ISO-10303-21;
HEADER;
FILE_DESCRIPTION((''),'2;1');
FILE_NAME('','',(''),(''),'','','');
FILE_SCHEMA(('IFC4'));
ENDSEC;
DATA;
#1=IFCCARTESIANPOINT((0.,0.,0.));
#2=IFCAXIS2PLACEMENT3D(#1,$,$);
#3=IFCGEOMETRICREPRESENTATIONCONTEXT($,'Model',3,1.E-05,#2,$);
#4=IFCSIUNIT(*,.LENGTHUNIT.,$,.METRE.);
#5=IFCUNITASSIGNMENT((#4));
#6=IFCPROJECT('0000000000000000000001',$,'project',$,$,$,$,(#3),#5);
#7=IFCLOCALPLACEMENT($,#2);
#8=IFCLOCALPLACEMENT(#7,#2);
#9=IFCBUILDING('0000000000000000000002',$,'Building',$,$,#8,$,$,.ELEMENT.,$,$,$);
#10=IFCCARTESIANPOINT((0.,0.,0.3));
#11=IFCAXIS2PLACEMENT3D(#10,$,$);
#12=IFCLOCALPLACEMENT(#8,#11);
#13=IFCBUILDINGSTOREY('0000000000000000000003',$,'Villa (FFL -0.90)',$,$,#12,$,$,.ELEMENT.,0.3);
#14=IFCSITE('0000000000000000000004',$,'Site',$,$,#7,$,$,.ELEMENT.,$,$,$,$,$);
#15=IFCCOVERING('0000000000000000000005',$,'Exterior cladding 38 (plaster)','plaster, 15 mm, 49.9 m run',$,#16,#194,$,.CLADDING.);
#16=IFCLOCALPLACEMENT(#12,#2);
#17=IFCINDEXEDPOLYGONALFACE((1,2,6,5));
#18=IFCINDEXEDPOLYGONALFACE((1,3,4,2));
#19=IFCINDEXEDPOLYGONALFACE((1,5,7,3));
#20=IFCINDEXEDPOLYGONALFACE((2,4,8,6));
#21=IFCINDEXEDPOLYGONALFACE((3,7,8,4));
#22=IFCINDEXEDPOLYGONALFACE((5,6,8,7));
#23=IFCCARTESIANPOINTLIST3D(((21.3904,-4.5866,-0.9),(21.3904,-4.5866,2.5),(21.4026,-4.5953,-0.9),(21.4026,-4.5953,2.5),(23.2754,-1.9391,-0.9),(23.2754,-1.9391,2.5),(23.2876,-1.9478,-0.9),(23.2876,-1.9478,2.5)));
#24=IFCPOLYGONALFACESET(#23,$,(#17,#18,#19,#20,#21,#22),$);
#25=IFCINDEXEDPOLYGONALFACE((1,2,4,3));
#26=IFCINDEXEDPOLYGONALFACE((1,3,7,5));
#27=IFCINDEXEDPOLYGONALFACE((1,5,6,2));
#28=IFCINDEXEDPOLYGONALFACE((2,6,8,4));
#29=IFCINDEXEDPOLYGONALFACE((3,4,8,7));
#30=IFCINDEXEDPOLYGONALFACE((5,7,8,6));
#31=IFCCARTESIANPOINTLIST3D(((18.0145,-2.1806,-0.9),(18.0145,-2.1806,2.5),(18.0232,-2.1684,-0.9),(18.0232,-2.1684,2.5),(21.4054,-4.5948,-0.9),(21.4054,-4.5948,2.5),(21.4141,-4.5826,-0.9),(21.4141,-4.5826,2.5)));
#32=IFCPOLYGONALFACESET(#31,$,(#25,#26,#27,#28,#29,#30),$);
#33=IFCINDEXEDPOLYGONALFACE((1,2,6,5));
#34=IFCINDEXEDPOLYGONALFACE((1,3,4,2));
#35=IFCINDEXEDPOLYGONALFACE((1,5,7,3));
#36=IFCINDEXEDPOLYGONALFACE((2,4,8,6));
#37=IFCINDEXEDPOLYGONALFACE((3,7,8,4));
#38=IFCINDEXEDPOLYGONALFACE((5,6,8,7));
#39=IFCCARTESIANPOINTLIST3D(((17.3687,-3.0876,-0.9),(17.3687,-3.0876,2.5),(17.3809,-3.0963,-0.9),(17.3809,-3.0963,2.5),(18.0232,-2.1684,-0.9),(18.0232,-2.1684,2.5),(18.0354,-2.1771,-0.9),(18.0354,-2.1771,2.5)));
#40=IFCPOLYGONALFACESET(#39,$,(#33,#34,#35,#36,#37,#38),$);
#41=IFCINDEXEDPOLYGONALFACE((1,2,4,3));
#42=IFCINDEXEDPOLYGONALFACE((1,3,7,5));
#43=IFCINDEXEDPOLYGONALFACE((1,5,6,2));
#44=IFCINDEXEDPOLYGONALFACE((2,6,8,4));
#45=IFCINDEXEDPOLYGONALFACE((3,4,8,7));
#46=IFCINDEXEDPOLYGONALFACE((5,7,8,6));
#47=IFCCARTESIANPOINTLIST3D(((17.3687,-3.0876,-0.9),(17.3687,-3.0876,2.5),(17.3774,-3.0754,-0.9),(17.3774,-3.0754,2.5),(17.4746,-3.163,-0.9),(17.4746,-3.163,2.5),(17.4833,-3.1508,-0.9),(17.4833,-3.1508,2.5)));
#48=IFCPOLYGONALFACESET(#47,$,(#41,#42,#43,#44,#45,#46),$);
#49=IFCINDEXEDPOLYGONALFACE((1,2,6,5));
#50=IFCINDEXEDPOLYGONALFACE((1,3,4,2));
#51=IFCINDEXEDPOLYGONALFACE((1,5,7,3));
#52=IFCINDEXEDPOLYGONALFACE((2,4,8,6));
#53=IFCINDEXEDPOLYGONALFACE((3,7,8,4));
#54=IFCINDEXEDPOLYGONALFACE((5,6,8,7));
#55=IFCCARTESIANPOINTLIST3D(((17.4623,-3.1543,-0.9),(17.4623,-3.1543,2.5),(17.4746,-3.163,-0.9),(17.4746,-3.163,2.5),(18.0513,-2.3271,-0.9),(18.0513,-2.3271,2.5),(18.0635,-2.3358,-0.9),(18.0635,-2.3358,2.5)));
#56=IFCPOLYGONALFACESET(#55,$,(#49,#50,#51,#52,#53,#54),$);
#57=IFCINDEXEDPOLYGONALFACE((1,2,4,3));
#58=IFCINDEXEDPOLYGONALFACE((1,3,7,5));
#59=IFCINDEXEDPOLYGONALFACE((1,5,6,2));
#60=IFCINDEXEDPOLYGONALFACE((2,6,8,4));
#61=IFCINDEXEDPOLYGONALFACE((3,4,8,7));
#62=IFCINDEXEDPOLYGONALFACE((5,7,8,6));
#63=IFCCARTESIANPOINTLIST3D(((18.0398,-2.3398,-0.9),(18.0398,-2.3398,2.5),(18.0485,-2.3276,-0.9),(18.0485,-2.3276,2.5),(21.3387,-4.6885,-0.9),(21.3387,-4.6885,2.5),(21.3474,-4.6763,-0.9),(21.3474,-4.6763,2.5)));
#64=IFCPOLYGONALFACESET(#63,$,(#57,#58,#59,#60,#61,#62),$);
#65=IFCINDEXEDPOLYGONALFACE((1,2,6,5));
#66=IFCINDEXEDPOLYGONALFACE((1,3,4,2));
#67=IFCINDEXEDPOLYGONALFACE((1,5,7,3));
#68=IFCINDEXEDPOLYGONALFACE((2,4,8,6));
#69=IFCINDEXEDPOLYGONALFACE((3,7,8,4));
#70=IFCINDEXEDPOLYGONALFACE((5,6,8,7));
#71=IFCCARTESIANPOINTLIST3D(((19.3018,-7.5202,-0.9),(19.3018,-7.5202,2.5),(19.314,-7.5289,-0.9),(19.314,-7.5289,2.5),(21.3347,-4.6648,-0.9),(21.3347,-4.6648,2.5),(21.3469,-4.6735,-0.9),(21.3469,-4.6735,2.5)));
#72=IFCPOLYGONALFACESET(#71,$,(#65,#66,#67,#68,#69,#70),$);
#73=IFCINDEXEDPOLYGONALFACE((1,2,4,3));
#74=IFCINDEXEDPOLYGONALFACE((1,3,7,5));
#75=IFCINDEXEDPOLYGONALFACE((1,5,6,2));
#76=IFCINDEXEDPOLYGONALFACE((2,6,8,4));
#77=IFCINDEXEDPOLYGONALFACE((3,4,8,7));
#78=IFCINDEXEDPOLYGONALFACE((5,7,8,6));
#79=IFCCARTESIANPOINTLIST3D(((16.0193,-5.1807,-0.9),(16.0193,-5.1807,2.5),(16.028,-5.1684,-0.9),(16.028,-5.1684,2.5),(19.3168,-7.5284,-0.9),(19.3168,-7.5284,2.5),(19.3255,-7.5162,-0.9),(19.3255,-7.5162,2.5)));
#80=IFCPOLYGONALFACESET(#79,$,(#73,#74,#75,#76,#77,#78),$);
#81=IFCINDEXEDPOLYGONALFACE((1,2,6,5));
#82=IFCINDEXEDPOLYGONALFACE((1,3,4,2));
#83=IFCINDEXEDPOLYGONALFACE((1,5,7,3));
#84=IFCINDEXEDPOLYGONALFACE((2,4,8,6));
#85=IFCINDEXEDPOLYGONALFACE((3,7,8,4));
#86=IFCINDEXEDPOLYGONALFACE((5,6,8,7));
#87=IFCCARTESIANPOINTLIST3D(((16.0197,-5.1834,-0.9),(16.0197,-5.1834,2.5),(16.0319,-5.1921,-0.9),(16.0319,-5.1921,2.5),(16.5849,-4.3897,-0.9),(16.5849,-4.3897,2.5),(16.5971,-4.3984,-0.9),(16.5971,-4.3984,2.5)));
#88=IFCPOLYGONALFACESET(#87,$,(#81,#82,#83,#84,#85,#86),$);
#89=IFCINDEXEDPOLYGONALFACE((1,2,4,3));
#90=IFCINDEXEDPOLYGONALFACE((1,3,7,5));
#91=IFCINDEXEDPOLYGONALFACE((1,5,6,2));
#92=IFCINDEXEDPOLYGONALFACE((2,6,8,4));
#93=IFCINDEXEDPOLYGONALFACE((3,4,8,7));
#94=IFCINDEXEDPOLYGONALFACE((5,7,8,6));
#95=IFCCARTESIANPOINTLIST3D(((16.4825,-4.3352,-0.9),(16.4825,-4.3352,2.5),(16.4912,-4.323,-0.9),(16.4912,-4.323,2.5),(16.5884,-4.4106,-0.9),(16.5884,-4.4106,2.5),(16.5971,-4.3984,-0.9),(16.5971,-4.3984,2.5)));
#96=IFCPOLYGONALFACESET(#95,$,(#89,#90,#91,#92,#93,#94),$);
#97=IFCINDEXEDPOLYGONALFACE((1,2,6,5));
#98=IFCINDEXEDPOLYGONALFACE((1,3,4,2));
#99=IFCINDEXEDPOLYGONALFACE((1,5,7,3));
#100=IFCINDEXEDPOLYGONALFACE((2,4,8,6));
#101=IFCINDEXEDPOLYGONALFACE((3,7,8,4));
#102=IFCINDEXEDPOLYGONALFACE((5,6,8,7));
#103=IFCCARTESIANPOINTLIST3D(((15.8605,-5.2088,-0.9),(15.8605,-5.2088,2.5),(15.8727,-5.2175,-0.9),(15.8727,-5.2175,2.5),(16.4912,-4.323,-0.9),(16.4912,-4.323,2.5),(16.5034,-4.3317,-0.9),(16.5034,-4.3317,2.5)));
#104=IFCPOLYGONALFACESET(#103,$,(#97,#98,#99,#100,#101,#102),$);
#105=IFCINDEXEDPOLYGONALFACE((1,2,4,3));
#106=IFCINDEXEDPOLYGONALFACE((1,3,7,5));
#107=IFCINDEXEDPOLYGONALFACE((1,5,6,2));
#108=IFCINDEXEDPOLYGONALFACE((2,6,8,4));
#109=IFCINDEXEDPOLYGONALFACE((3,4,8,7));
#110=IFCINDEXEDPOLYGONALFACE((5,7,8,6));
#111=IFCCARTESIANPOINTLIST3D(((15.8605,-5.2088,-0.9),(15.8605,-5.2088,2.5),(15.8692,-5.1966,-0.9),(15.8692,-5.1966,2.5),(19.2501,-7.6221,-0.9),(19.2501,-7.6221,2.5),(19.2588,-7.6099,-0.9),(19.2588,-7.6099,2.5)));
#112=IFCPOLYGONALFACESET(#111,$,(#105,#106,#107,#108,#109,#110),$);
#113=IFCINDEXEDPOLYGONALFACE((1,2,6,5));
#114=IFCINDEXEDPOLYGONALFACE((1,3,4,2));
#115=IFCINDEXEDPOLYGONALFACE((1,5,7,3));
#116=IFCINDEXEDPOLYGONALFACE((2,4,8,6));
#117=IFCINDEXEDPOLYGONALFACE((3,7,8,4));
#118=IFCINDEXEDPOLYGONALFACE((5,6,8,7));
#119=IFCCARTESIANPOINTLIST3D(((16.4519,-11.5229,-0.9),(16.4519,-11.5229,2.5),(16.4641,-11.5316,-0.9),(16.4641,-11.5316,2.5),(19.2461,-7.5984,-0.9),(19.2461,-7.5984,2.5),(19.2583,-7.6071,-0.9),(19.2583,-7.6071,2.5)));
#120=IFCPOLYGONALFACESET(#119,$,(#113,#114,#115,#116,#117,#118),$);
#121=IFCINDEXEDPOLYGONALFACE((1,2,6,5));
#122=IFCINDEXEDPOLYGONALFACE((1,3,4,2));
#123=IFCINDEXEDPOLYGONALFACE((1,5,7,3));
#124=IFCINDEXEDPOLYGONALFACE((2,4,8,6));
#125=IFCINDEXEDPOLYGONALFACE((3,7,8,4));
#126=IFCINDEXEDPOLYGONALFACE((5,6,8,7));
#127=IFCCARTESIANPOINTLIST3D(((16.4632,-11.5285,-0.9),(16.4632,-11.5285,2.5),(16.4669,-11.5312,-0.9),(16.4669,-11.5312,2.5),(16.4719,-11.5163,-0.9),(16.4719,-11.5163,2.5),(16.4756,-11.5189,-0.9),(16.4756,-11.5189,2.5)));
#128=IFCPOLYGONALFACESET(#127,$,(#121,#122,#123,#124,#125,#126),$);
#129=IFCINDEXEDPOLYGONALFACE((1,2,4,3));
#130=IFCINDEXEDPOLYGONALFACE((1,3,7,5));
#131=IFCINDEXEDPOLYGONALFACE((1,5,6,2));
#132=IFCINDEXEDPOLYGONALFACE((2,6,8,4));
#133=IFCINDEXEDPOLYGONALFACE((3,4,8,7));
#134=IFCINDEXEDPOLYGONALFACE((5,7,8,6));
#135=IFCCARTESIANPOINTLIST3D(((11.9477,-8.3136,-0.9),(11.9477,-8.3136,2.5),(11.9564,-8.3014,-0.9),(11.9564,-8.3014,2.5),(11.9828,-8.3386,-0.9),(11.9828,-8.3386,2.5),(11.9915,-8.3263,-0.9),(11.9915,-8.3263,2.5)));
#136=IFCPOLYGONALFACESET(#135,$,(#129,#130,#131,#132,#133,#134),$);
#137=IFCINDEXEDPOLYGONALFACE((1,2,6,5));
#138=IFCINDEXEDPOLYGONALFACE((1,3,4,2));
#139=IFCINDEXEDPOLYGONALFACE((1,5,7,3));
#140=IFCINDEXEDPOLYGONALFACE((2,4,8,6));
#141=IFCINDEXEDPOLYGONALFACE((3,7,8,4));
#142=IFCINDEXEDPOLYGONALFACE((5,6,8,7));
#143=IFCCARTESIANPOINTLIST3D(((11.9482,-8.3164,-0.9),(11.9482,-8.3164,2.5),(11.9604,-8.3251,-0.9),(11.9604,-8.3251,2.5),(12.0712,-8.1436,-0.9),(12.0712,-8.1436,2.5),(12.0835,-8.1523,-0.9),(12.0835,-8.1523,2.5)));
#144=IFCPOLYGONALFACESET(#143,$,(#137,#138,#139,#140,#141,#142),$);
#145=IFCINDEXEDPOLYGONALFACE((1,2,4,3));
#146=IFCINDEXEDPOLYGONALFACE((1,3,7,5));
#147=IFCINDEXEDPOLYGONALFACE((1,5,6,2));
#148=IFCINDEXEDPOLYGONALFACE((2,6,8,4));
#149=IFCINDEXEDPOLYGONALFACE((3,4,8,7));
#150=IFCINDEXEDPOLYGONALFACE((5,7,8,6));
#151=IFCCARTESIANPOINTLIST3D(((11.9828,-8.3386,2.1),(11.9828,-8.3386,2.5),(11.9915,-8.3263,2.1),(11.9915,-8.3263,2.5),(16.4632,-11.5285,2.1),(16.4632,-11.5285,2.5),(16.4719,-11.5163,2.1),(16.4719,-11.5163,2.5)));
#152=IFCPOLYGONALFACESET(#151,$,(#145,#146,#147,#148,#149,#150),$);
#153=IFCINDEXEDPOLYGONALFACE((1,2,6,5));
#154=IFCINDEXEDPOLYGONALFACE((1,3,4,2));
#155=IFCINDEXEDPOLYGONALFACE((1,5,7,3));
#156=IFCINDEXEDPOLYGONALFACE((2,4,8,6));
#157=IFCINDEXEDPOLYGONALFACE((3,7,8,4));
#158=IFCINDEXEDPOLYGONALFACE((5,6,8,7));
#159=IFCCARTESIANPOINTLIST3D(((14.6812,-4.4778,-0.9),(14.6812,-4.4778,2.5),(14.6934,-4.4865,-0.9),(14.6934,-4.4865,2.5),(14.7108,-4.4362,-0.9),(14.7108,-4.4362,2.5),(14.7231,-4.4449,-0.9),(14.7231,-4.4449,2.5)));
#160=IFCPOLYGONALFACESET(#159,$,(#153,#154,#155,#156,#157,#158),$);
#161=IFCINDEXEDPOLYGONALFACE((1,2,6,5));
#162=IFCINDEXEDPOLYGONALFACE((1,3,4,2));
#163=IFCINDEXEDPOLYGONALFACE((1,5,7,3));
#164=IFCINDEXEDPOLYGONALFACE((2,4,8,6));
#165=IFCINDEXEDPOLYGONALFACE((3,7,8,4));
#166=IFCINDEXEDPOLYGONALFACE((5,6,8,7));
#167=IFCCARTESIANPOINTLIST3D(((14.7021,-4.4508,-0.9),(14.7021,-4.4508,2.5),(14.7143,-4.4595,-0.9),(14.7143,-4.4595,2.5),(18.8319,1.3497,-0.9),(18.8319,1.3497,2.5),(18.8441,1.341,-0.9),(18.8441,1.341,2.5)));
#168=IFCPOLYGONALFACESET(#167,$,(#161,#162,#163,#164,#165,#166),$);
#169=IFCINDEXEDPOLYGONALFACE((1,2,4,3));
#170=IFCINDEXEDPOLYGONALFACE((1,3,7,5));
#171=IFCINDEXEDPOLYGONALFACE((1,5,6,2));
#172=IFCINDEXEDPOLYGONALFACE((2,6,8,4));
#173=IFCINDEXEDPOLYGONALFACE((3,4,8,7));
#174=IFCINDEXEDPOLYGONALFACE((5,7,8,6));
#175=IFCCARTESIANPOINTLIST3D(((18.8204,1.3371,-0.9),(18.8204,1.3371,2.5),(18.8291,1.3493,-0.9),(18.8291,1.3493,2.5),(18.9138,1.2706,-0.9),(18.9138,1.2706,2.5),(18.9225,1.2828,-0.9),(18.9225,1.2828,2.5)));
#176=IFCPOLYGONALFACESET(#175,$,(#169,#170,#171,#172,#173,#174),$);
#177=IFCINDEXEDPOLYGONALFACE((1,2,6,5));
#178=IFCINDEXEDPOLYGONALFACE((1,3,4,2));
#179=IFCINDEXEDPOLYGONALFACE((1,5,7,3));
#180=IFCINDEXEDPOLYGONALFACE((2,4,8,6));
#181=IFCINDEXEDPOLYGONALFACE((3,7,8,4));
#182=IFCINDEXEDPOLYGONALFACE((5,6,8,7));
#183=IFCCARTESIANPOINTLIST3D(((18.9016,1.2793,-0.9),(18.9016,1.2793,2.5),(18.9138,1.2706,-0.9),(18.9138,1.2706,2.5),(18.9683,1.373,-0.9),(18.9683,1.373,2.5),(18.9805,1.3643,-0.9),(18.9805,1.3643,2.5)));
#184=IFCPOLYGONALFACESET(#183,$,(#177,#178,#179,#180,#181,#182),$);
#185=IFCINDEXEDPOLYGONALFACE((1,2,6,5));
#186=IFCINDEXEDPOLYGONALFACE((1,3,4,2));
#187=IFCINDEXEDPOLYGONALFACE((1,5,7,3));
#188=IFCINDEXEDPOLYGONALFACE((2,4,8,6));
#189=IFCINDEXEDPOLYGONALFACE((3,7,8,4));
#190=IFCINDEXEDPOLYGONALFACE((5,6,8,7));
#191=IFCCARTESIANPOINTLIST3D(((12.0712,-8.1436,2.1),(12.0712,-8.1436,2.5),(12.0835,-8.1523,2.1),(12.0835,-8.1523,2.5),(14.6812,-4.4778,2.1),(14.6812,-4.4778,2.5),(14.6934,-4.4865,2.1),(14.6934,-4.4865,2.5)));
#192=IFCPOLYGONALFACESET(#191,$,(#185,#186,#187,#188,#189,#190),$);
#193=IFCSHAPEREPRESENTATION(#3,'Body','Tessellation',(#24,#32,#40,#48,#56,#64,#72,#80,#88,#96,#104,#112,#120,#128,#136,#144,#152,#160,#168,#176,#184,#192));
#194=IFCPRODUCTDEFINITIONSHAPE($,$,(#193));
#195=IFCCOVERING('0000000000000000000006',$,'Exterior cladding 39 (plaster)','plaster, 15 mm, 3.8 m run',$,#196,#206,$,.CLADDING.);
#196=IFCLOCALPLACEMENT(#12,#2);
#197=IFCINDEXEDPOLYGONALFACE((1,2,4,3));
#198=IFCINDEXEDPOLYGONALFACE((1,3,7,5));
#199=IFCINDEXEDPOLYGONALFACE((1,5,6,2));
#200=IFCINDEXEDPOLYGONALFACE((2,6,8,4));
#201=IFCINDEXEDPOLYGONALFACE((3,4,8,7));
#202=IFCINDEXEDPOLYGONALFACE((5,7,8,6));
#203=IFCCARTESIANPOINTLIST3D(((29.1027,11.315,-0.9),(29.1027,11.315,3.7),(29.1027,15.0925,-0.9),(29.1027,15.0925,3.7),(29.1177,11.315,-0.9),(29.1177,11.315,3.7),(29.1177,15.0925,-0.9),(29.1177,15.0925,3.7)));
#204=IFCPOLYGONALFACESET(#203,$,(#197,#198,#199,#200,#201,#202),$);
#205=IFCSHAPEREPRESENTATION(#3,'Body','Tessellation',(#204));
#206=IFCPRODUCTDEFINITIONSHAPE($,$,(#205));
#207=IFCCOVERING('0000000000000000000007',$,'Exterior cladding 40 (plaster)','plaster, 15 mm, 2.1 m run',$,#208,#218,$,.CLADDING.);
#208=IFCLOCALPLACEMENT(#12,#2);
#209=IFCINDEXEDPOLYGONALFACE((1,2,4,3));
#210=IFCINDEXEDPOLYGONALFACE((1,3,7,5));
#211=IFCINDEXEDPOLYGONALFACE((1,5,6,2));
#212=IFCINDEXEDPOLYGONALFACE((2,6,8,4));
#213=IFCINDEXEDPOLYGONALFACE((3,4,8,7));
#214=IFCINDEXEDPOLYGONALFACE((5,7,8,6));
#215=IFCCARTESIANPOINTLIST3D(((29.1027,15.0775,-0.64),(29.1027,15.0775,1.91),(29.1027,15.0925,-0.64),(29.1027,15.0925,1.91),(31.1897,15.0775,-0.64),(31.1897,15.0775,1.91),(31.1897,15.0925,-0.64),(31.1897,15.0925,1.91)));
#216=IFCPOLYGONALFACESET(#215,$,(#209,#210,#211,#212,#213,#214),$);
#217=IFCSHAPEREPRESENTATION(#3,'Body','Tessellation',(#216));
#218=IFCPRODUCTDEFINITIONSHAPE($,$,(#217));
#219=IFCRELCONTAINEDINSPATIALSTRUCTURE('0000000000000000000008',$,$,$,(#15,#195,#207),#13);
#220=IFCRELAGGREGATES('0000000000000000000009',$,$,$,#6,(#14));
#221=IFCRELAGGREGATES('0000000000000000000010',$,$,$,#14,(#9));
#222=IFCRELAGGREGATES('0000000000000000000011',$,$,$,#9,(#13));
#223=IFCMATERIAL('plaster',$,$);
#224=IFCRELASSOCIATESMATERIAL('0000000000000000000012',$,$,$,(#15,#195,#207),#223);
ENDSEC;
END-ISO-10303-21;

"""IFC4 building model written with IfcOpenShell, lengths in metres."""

from ifc_helpers import new_model, si_unit, frame, origin, origin_with_axes, place, context, project, spatial, polyline, outline, extrude, material, element, save


model = new_model("IFC4")

# Units and contexts
model_context = context("Model", 3, precision=1e-05, world=origin())
ifc_project = project(units=[si_unit("LENGTHUNIT", "METRE")], contexts=[model_context])

# Site, building, storey
site_placement = place(None, origin())
site = spatial("IfcSite", under=ifc_project, at=site_placement, Name="Site", CompositionType="ELEMENT")
building_placement = place(site_placement, origin())
building = spatial("IfcBuilding", under=site, at=building_placement, Name="Building", CompositionType="ELEMENT")
storey_placement = place(building_placement, frame((0.0, 0.0, 0.3)))
storey = spatial("IfcBuildingStorey", under=building, at=storey_placement, Name="Villa (FFL -0.90)", CompositionType="ELEMENT", Elevation=0.3)

# Coverings
ifc_material = material(Name="plaster")
covering_1_placement = place(storey_placement, origin_with_axes())
element("IfcCovering", 1, at=covering_1_placement, inside=storey, material=ifc_material, Name="Exterior cladding 38 (plaster)", Description="plaster, 15 mm, 49.9 m run", PredefinedType="CLADDING", context=model_context, shape_type="SweptSolid", body=[
    extrude(outline(polyline([(23.2754, -1.9391), (21.3904, -4.5866), (21.4026, -4.5953), (23.2876, -1.9478), (23.2754, -1.9391)])), frame((0.0, 0.0, -0.9)), (0.0, 0.0, 1.0), 3.4),
    extrude(outline(polyline([(21.4141, -4.5826), (18.0232, -2.1684), (18.0145, -2.1806), (21.4054, -4.5949), (21.4141, -4.5826)])), frame((0.0, 0.0, -0.9)), (0.0, 0.0, 1.0), 3.4),
    extrude(outline(polyline([(18.0232, -2.1684), (17.3687, -3.0876), (17.3809, -3.0963), (18.0354, -2.1771), (18.0232, -2.1684)])), frame((0.0, 0.0, -0.9)), (0.0, 0.0, 1.0), 3.4),
    extrude(outline(polyline([(17.3687, -3.0876), (17.4746, -3.163), (17.4833, -3.1508), (17.3774, -3.0754), (17.3687, -3.0876)])), frame((0.0, 0.0, -0.9)), (0.0, 0.0, 1.0), 3.4),
    extrude(outline(polyline([(17.4746, -3.163), (18.0635, -2.3358), (18.0513, -2.3271), (17.4623, -3.1543), (17.4746, -3.163)])), frame((0.0, 0.0, -0.9)), (0.0, 0.0, 1.0), 3.4),
    extrude(outline(polyline([(18.0398, -2.3398), (21.3387, -4.6885), (21.3474, -4.6763), (18.0485, -2.3276), (18.0398, -2.3398)])), frame((0.0, 0.0, -0.9)), (0.0, 0.0, 1.0), 3.4),
    extrude(outline(polyline([(21.3347, -4.6648), (19.3018, -7.5202), (19.314, -7.5289), (21.3469, -4.6735), (21.3347, -4.6648)])), frame((0.0, 0.0, -0.9)), (0.0, 0.0, 1.0), 3.4),
    extrude(outline(polyline([(19.3255, -7.5162), (16.028, -5.1684), (16.0193, -5.1807), (19.3168, -7.5284), (19.3255, -7.5162)])), frame((0.0, 0.0, -0.9)), (0.0, 0.0, 1.0), 3.4),
    extrude(outline(polyline([(16.0319, -5.1921), (16.5971, -4.3984), (16.5849, -4.3897), (16.0197, -5.1834), (16.0319, -5.1921)])), frame((0.0, 0.0, -0.9)), (0.0, 0.0, 1.0), 3.4),
    extrude(outline(polyline([(16.5971, -4.3984), (16.4912, -4.323), (16.4825, -4.3352), (16.5884, -4.4106), (16.5971, -4.3984)])), frame((0.0, 0.0, -0.9)), (0.0, 0.0, 1.0), 3.4),
    extrude(outline(polyline([(16.4912, -4.323), (15.8605, -5.2088), (15.8727, -5.2175), (16.5034, -4.3317), (16.4912, -4.323)])), frame((0.0, 0.0, -0.9)), (0.0, 0.0, 1.0), 3.4),
    extrude(outline(polyline([(15.8605, -5.2088), (19.2501, -7.6221), (19.2588, -7.6099), (15.8692, -5.1966), (15.8605, -5.2088)])), frame((0.0, 0.0, -0.9)), (0.0, 0.0, 1.0), 3.4),
    extrude(outline(polyline([(19.2461, -7.5984), (16.4519, -11.5229), (16.4641, -11.5316), (19.2583, -7.6071), (19.2461, -7.5984)])), frame((0.0, 0.0, -0.9)), (0.0, 0.0, 1.0), 3.4),
    extrude(outline(polyline([(16.4756, -11.5189), (16.4719, -11.5163), (16.4632, -11.5285), (16.4669, -11.5312), (16.4756, -11.5189)])), frame((0.0, 0.0, -0.9)), (0.0, 0.0, 1.0), 3.4),
    extrude(outline(polyline([(11.9915, -8.3263), (11.9564, -8.3014), (11.9477, -8.3136), (11.9828, -8.3386), (11.9915, -8.3263)])), frame((0.0, 0.0, -0.9)), (0.0, 0.0, 1.0), 3.4),
    extrude(outline(polyline([(11.9604, -8.3251), (12.0835, -8.1523), (12.0712, -8.1436), (11.9482, -8.3164), (11.9604, -8.3251)])), frame((0.0, 0.0, -0.9)), (0.0, 0.0, 1.0), 3.4),
    extrude(outline(polyline([(16.4719, -11.5163), (11.9915, -8.3263), (11.9828, -8.3386), (16.4632, -11.5285), (16.4719, -11.5163)])), frame((0.0, 0.0, 2.1)), (0.0, 0.0, 1.0), 0.4),
    extrude(outline(polyline([(14.6934, -4.4865), (14.7231, -4.4449), (14.7109, -4.4362), (14.6812, -4.4778), (14.6934, -4.4865)])), frame((0.0, 0.0, -0.9)), (0.0, 0.0, 1.0), 3.4),
    extrude(outline(polyline([(14.7143, -4.4595), (18.8441, 1.341), (18.8319, 1.3497), (14.7021, -4.4508), (14.7143, -4.4595)])), frame((0.0, 0.0, -0.9)), (0.0, 0.0, 1.0), 3.4),
    extrude(outline(polyline([(18.8204, 1.3371), (18.9138, 1.2706), (18.9225, 1.2828), (18.8291, 1.3493), (18.8204, 1.3371)])), frame((0.0, 0.0, -0.9)), (0.0, 0.0, 1.0), 3.4),
    extrude(outline(polyline([(18.9138, 1.2706), (18.9805, 1.3643), (18.9683, 1.373), (18.9016, 1.2793), (18.9138, 1.2706)])), frame((0.0, 0.0, -0.9)), (0.0, 0.0, 1.0), 3.4),
    extrude(outline(polyline([(12.0835, -8.1523), (14.6934, -4.4865), (14.6812, -4.4778), (12.0712, -8.1436), (12.0835, -8.1523)])), frame((0.0, 0.0, 2.1)), (0.0, 0.0, 1.0), 0.4),
])
covering_2_placement = place(storey_placement, origin_with_axes())
element("IfcCovering", 2, at=covering_2_placement, inside=storey, material=ifc_material, Name="Exterior cladding 39 (plaster)", Description="plaster, 15 mm, 3.8 m run", PredefinedType="CLADDING", context=model_context, shape_type="SweptSolid", body=[
    extrude(outline(polyline([(29.1177, 11.315), (29.1177, 15.0925), (29.1027, 15.0925), (29.1027, 11.315), (29.1177, 11.315)])), frame((0.0, 0.0, -0.9)), (0.0, 0.0, 1.0), 4.6),
])
covering_3_placement = place(storey_placement, origin_with_axes())
element("IfcCovering", 3, at=covering_3_placement, inside=storey, material=ifc_material, Name="Exterior cladding 40 (plaster)", Description="plaster, 15 mm, 2.1 m run", PredefinedType="CLADDING", context=model_context, shape_type="SweptSolid", body=[
    extrude(outline(polyline([(29.1027, 15.0775), (31.1897, 15.0775), (31.1897, 15.0925), (29.1027, 15.0925), (29.1027, 15.0775)])), frame((0.0, 0.0, -0.64)), (0.0, 0.0, 1.0), 2.55),
])

save(model, "model.ifc")
